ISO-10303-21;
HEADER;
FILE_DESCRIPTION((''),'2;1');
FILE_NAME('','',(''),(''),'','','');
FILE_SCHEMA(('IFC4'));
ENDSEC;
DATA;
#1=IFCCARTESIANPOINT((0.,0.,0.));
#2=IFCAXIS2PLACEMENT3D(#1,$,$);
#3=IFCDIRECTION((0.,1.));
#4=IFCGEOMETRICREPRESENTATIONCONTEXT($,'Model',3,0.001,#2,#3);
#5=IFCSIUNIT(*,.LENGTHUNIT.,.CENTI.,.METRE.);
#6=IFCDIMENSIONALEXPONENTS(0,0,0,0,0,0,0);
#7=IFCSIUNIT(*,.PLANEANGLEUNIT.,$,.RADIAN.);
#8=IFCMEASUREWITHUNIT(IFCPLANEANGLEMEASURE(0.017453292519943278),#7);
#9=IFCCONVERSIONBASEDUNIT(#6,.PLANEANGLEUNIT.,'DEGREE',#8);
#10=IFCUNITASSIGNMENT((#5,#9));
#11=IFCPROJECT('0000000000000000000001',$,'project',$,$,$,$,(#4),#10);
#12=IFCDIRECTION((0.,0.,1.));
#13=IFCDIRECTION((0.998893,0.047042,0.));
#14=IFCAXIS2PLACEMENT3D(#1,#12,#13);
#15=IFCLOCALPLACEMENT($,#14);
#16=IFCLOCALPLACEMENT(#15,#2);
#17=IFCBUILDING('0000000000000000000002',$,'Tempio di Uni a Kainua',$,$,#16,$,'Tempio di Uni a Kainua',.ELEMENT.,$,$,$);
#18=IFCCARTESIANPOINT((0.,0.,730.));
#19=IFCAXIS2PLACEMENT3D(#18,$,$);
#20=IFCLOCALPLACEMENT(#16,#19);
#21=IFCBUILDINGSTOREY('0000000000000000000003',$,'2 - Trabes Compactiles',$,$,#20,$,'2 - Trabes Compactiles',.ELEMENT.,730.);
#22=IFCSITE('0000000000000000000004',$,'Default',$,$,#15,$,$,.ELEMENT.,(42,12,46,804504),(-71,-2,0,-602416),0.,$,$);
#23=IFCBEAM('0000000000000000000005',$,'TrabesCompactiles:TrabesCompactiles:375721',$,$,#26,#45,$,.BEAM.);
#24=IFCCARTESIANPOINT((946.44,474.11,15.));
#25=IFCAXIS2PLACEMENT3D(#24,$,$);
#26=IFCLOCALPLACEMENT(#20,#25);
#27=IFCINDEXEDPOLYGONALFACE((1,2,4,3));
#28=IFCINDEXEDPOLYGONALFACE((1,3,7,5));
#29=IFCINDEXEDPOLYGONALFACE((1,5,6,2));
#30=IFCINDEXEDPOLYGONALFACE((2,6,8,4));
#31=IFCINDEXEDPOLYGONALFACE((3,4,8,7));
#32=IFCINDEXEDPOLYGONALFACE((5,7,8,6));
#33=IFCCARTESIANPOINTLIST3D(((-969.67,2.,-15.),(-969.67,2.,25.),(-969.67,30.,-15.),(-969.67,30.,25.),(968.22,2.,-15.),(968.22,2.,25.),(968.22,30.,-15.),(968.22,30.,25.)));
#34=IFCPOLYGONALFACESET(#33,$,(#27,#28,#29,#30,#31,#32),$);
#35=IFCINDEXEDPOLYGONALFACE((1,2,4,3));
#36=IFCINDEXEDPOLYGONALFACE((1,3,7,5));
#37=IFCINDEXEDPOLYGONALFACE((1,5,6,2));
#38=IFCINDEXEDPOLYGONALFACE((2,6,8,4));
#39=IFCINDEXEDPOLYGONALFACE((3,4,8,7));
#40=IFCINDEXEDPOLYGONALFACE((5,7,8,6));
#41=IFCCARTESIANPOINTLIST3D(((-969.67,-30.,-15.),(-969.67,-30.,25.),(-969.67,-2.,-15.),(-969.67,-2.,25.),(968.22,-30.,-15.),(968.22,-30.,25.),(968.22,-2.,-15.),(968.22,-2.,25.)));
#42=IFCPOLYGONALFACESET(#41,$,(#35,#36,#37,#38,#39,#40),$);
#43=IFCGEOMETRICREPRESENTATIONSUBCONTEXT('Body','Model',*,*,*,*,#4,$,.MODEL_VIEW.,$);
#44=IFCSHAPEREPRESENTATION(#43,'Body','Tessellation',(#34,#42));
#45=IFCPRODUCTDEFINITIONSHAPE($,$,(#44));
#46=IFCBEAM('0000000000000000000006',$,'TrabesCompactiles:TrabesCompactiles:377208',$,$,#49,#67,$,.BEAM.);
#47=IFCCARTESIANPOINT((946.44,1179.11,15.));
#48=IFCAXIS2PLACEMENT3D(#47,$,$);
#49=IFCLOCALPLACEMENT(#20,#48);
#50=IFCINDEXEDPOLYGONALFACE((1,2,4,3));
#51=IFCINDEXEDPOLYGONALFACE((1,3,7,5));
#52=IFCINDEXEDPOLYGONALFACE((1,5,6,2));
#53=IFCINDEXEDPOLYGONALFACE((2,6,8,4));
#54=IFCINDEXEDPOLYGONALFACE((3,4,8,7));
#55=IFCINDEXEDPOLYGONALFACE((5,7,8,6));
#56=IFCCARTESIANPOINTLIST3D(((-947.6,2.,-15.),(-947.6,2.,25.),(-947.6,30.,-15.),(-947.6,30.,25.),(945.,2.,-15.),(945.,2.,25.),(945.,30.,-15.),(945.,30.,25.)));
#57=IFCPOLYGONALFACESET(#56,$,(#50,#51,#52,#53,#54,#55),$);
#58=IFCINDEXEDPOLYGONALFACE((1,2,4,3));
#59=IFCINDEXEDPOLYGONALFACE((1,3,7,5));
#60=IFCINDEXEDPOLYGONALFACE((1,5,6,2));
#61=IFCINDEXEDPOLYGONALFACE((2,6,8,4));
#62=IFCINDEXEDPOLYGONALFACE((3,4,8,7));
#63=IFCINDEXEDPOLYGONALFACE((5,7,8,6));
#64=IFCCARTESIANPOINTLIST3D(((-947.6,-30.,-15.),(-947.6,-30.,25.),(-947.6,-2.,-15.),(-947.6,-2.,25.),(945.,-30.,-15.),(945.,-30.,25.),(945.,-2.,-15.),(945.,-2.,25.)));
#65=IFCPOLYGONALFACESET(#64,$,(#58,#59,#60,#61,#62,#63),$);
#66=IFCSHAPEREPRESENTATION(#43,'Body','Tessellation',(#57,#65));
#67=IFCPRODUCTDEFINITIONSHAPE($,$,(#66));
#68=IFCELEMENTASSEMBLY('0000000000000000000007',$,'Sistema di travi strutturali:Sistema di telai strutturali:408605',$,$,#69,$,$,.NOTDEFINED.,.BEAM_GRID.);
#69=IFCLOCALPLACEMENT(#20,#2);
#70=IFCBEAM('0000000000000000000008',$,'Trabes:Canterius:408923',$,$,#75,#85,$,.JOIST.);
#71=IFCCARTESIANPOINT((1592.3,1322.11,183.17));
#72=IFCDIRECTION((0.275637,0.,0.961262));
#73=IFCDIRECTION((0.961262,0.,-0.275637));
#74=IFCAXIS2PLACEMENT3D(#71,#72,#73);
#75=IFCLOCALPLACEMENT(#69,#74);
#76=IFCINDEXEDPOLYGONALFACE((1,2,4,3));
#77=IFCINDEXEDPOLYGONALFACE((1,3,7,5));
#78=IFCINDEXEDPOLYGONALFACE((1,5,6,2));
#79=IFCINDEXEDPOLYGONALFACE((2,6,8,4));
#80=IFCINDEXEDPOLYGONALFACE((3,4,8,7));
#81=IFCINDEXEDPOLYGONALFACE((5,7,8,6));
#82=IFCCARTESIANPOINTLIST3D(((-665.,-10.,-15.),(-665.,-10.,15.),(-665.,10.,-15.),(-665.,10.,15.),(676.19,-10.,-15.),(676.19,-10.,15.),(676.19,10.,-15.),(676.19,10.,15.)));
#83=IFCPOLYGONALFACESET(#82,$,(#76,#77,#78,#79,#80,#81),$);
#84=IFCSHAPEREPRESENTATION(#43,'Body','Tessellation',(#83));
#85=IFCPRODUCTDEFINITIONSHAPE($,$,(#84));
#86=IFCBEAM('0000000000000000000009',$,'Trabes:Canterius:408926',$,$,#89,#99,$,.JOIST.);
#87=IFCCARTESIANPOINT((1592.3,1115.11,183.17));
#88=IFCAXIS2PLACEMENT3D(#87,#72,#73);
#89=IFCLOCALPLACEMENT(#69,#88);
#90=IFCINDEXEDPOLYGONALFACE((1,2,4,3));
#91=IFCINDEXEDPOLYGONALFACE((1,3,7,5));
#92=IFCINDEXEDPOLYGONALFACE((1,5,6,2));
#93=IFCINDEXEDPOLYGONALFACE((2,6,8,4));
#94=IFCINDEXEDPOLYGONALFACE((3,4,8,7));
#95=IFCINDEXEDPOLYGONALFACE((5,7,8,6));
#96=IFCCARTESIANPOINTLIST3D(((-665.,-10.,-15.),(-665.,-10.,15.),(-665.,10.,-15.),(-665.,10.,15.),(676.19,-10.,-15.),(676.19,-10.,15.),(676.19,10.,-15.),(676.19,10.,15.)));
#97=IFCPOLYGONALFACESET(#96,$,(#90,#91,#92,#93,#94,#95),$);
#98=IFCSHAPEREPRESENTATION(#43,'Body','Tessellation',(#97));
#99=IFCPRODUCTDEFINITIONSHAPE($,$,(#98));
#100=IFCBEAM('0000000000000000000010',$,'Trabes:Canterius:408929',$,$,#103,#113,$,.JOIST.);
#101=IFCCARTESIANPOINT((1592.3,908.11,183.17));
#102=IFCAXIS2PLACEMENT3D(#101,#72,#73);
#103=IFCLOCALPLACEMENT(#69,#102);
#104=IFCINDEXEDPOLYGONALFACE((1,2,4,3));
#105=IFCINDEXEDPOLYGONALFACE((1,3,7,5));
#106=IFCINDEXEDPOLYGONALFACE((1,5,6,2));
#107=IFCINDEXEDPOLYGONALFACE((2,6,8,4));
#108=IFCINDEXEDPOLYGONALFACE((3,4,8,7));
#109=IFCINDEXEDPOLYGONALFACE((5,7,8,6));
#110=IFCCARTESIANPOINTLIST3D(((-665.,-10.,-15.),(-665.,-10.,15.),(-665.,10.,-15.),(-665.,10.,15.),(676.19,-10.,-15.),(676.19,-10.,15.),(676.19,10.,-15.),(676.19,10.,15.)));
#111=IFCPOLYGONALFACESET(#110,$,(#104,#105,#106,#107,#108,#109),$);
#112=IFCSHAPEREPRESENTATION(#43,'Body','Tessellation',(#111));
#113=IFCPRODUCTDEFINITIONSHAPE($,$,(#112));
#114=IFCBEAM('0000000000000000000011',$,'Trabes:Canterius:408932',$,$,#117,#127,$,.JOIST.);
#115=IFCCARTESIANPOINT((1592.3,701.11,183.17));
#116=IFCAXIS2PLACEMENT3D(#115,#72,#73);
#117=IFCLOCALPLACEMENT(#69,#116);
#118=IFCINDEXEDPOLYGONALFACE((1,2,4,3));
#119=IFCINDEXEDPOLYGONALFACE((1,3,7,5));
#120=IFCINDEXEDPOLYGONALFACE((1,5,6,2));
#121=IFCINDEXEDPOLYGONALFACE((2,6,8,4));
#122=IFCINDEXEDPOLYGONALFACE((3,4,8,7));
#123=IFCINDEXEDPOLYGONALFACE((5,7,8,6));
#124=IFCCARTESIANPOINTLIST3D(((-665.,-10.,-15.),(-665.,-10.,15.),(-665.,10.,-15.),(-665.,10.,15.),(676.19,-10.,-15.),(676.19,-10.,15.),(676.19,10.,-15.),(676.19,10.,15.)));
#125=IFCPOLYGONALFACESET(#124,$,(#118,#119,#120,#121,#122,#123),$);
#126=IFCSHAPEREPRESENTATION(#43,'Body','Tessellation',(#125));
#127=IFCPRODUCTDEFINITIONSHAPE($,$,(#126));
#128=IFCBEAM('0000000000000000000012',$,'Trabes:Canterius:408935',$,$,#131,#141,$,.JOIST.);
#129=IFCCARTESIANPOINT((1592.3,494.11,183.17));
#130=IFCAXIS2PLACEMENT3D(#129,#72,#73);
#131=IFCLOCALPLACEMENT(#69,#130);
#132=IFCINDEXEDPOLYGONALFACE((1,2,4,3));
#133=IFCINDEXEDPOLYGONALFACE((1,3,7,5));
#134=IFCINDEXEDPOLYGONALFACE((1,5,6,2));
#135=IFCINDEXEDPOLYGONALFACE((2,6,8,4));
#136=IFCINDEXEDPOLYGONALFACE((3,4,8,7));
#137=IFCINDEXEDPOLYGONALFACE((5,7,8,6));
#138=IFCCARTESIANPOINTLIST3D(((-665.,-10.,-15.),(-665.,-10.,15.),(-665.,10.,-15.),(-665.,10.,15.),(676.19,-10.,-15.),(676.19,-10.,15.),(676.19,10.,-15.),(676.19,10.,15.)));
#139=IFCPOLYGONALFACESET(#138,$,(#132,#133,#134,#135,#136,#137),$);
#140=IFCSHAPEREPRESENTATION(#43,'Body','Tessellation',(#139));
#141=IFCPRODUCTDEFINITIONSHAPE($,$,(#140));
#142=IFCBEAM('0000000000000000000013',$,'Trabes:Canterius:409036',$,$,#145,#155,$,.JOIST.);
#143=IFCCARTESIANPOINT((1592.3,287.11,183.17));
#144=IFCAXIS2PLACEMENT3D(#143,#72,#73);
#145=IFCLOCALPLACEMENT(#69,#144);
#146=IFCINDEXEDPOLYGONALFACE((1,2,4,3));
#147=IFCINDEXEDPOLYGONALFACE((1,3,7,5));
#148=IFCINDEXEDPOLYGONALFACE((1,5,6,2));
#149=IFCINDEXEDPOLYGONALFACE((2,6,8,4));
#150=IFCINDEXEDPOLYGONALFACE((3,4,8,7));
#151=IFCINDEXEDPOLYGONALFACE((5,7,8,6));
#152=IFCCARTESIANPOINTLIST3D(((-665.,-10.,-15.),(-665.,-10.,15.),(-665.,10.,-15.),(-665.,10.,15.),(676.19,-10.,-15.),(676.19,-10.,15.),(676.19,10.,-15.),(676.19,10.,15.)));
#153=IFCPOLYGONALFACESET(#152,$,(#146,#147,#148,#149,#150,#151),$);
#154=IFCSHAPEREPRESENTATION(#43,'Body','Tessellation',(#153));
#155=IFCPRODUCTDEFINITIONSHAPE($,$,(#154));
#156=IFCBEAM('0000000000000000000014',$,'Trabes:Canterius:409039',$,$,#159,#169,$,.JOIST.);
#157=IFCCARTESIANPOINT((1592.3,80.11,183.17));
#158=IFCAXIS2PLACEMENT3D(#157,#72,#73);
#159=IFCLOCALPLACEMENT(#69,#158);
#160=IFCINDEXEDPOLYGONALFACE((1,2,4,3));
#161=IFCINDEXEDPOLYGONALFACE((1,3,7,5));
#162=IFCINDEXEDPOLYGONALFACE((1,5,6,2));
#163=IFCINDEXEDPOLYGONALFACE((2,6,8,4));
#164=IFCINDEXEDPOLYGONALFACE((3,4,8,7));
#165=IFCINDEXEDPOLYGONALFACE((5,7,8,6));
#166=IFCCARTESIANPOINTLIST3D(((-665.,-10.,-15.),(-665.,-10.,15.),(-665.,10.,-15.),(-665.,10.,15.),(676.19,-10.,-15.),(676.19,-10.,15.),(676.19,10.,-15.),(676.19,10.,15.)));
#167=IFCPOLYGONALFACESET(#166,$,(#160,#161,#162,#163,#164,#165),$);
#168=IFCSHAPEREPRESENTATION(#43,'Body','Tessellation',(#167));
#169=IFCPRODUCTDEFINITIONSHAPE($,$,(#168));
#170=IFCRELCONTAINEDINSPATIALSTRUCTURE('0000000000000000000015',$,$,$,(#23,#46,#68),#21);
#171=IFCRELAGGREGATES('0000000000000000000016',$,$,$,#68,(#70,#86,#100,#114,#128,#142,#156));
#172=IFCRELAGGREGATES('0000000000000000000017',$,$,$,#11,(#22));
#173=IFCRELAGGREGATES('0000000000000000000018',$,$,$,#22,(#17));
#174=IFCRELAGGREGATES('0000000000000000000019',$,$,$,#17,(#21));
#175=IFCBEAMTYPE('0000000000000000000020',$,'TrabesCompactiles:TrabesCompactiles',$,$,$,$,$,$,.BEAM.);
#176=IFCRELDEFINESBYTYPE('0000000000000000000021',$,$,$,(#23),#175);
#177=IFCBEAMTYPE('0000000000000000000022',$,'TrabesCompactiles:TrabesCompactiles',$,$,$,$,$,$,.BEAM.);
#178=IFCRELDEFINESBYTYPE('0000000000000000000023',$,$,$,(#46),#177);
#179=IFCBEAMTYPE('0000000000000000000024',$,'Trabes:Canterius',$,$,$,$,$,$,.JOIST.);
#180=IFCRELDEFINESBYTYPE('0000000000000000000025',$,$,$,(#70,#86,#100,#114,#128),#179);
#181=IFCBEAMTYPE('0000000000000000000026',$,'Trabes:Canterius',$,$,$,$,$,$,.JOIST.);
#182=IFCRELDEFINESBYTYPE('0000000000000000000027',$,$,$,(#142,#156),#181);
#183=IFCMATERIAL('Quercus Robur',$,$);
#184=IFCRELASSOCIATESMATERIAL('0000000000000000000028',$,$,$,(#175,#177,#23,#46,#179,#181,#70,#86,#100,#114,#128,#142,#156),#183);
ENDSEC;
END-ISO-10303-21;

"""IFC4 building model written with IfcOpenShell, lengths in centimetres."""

from ifc_helpers import new_model, entity, si_unit, converted_unit, direction, frame, frame_2d, origin, origin_2d_with_axis, place, context, subcontext, project, spatial, rectangle, extrude, source, transform, mapped, material, material_profile, profile_set, profile_usage, type_object, type_shapes, element, aggregate, save


model = new_model("IFC4")

# Units and contexts
model_context = context("Model", 3, precision=0.001, world=origin(), true_north=direction((0.0, 1.0)))
body_context = subcontext(model_context, "Body", "Model", "MODEL_VIEW")
ifc_project = project(units=[si_unit("LENGTHUNIT", "METRE", prefix="CENTI"), converted_unit("PLANEANGLEUNIT", "DEGREE", entity("IfcPlaneAngleMeasure", 0.017453292519943278), si_unit("PLANEANGLEUNIT", "RADIAN"), dimensions=[0, 0, 0, 0, 0, 0, 0])], contexts=[model_context])

# Site, building, storey
site_placement = place(None, frame((0.0, 0.0, 0.0), z_axis=(0.0, 0.0, 1.0), x_axis=(0.998893, 0.047042, 0.0)))
site = spatial("IfcSite", under=ifc_project, at=site_placement, Name="Default", CompositionType="ELEMENT", RefLatitude=(42, 12, 46, 804504), RefLongitude=(-71, -2, 0, -602416), RefElevation=0.0)
building_placement = place(site_placement, origin())
building = spatial("IfcBuilding", under=site, at=building_placement, Name="Tempio di Uni a Kainua", LongName="Tempio di Uni a Kainua", CompositionType="ELEMENT")
storey_placement = place(building_placement, frame((0.0, 0.0, 730.0)))
storey = spatial("IfcBuildingStorey", under=building, at=storey_placement, Name="2 - Trabes Compactiles", LongName="2 - Trabes Compactiles", CompositionType="ELEMENT", Elevation=730.0)

# Beams
ifc_material = material(Name="Quercus Robur")
ifc_material_profile_1 = material_profile(ifc_material, rectangle(XDim=1937.89, YDim=28.0, at=origin_2d_with_axis()), Name="TrabesCompactiles")
ifc_material_profile_2 = material_profile(ifc_material, rectangle(XDim=1937.89, YDim=28.0, at=frame_2d((0.0, 0.0), x_axis=(1.0, 0.0))), Name="TrabesCompactiles")
ifc_profile_set_1 = profile_set([ifc_material_profile_1, ifc_material_profile_2], Name="TrabesCompactiles")
ifc_profile_usage_1 = profile_usage(ifc_profile_set_1)
beam_type_1 = type_object("IfcBeamType", Name="TrabesCompactiles:TrabesCompactiles", PredefinedType="BEAM", material=ifc_profile_set_1)
shared_shape_1 = source(origin(), body_context, "Body", "SweptSolid", [
    extrude(rectangle(XDim=1937.89, YDim=28.0, at=origin_2d_with_axis()), frame((-0.72, 16.0, -15.0), z_axis=(0.0, 0.0, 1.0), x_axis=(-1.0, 0.0, 0.0)), (0.0, 0.0, 1.0), 40.0),
    extrude(rectangle(XDim=1937.89, YDim=28.0, at=frame_2d((0.0, 0.0), x_axis=(1.0, 0.0))), frame((-0.72, -16.0, -15.0), z_axis=(0.0, 0.0, 1.0), x_axis=(-1.0, 0.0, 0.0)), (0.0, 0.0, 1.0), 40.0),
])
type_shapes(beam_type_1, [shared_shape_1])
beam_1_placement = place(storey_placement, frame((946.44, 474.11, 15.0)))
element("IfcBeam", 1, at=beam_1_placement, inside=storey, type_object=beam_type_1, material=ifc_profile_usage_1, Name="TrabesCompactiles:TrabesCompactiles:375721", PredefinedType="BEAM", context=body_context, shape_type="MappedRepresentation", body=[
    mapped(shared_shape_1, transform((0.0, 0.0, 0.0), scale=1.0)),
])
ifc_profile_usage_2 = profile_usage(ifc_profile_set_1, cardinal=8)
beam_type_2 = type_object("IfcBeamType", Name="TrabesCompactiles:TrabesCompactiles", PredefinedType="BEAM", material=ifc_profile_set_1)
shared_shape_2 = source(origin(), body_context, "Body", "SweptSolid", [
    extrude(rectangle(XDim=1892.6, YDim=28.0, at=origin_2d_with_axis()), frame((-1.3, 16.0, -15.0), z_axis=(0.0, 0.0, 1.0), x_axis=(-1.0, 0.0, 0.0)), (0.0, 0.0, 1.0), 40.0),
    extrude(rectangle(XDim=1892.6, YDim=28.0, at=frame_2d((0.0, 0.0), x_axis=(1.0, 0.0))), frame((-1.3, -16.0, -15.0), z_axis=(0.0, 0.0, 1.0), x_axis=(-1.0, 0.0, 0.0)), (0.0, 0.0, 1.0), 40.0),
])
type_shapes(beam_type_2, [shared_shape_2])
beam_2_placement = place(storey_placement, frame((946.44, 1179.11, 15.0)))
element("IfcBeam", 2, at=beam_2_placement, inside=storey, type_object=beam_type_2, material=ifc_profile_usage_2, Name="TrabesCompactiles:TrabesCompactiles:377208", PredefinedType="BEAM", context=body_context, shape_type="MappedRepresentation", body=[
    mapped(shared_shape_2, transform((0.0, 0.0, 0.0), scale=1.0)),
])

# Element assembly, beams
assembly_1_placement = place(storey_placement, origin())
assembly_1 = element("IfcElementAssembly", 3, at=assembly_1_placement, inside=storey, Name="Sistema di travi strutturali:Sistema di telai strutturali:408605", AssemblyPlace="NOTDEFINED", PredefinedType="BEAM_GRID")
ifc_material_profile_3 = material_profile(ifc_material, rectangle(XDim=2590.0, YDim=20.0, at=origin_2d_with_axis()), Name="Canterius")
ifc_profile_set_2 = profile_set([ifc_material_profile_3], Name="Canterius")
ifc_profile_usage_3 = profile_usage(ifc_profile_set_2, cardinal=8)
beam_type_3 = type_object("IfcBeamType", Name="Trabes:Canterius", PredefinedType="JOIST", material=ifc_profile_set_2)
shared_shape_3 = source(origin(), body_context, "Body", "SweptSolid", [
    extrude(rectangle(XDim=1341.19, YDim=20.0, at=origin_2d_with_axis()), frame((5.6, 0.0, -15.0)), (0.0, 0.0, 1.0), 30.0),
])
type_shapes(beam_type_3, [shared_shape_3])
beam_3_placement = place(assembly_1_placement, frame((1592.3, 1322.11, 183.17), z_axis=(0.275637, 0.0, 0.961262), x_axis=(0.961262, 0.0, -0.275637)))
beam_3 = element("IfcBeam", 4, at=beam_3_placement, type_object=beam_type_3, material=ifc_profile_usage_3, Name="Trabes:Canterius:408923", PredefinedType="JOIST", context=body_context, shape_type="MappedRepresentation", body=[
    mapped(shared_shape_3, transform((0.0, 0.0, 0.0), scale=1.0)),
])
beam_4_placement = place(assembly_1_placement, frame((1592.3, 1115.11, 183.17), z_axis=(0.275637, 0.0, 0.961262), x_axis=(0.961262, 0.0, -0.275637)))
beam_4 = element("IfcBeam", 5, at=beam_4_placement, type_object=beam_type_3, material=ifc_profile_usage_3, Name="Trabes:Canterius:408926", PredefinedType="JOIST", context=body_context, shape_type="MappedRepresentation", body=[
    mapped(shared_shape_3, transform((0.0, 0.0, 0.0), scale=1.0)),
])
beam_5_placement = place(assembly_1_placement, frame((1592.3, 908.11, 183.17), z_axis=(0.275637, 0.0, 0.961262), x_axis=(0.961262, 0.0, -0.275637)))
beam_5 = element("IfcBeam", 6, at=beam_5_placement, type_object=beam_type_3, material=ifc_profile_usage_3, Name="Trabes:Canterius:408929", PredefinedType="JOIST", context=body_context, shape_type="MappedRepresentation", body=[
    mapped(shared_shape_3, transform((0.0, 0.0, 0.0), scale=1.0)),
])
beam_6_placement = place(assembly_1_placement, frame((1592.3, 701.11, 183.17), z_axis=(0.275637, 0.0, 0.961262), x_axis=(0.961262, 0.0, -0.275637)))
beam_6 = element("IfcBeam", 7, at=beam_6_placement, type_object=beam_type_3, material=ifc_profile_usage_3, Name="Trabes:Canterius:408932", PredefinedType="JOIST", context=body_context, shape_type="MappedRepresentation", body=[
    mapped(shared_shape_3, transform((0.0, 0.0, 0.0), scale=1.0)),
])
beam_7_placement = place(assembly_1_placement, frame((1592.3, 494.11, 183.17), z_axis=(0.275637, 0.0, 0.961262), x_axis=(0.961262, 0.0, -0.275637)))
beam_7 = element("IfcBeam", 8, at=beam_7_placement, type_object=beam_type_3, material=ifc_profile_usage_3, Name="Trabes:Canterius:408935", PredefinedType="JOIST", context=body_context, shape_type="MappedRepresentation", body=[
    mapped(shared_shape_3, transform((0.0, 0.0, 0.0), scale=1.0)),
])
beam_type_4 = type_object("IfcBeamType", Name="Trabes:Canterius", PredefinedType="JOIST", material=ifc_profile_set_2)
shared_shape_4 = source(origin(), body_context, "Body", "SweptSolid", [
    extrude(rectangle(XDim=1341.19, YDim=20.0, at=origin_2d_with_axis()), frame((5.6, 0.0, -15.0)), (0.0, 0.0, 1.0), 30.0),
])
type_shapes(beam_type_4, [shared_shape_4])
beam_8_placement = place(assembly_1_placement, frame((1592.3, 287.11, 183.17), z_axis=(0.275637, 0.0, 0.961262), x_axis=(0.961262, 0.0, -0.275637)))
beam_8 = element("IfcBeam", 9, at=beam_8_placement, type_object=beam_type_4, material=ifc_profile_usage_3, Name="Trabes:Canterius:409036", PredefinedType="JOIST", context=body_context, shape_type="MappedRepresentation", body=[
    mapped(shared_shape_4, transform((0.0, 0.0, 0.0), scale=1.0)),
])
beam_9_placement = place(assembly_1_placement, frame((1592.3, 80.11, 183.17), z_axis=(0.275637, 0.0, 0.961262), x_axis=(0.961262, 0.0, -0.275637)))
beam_9 = element("IfcBeam", 10, at=beam_9_placement, type_object=beam_type_4, material=ifc_profile_usage_3, Name="Trabes:Canterius:409039", PredefinedType="JOIST", context=body_context, shape_type="MappedRepresentation", body=[
    mapped(shared_shape_4, transform((0.0, 0.0, 0.0), scale=1.0)),
])
aggregate(assembly_1, [beam_3, beam_4, beam_5, beam_6, beam_7, beam_8, beam_9])

save(model, "model.ifc")
